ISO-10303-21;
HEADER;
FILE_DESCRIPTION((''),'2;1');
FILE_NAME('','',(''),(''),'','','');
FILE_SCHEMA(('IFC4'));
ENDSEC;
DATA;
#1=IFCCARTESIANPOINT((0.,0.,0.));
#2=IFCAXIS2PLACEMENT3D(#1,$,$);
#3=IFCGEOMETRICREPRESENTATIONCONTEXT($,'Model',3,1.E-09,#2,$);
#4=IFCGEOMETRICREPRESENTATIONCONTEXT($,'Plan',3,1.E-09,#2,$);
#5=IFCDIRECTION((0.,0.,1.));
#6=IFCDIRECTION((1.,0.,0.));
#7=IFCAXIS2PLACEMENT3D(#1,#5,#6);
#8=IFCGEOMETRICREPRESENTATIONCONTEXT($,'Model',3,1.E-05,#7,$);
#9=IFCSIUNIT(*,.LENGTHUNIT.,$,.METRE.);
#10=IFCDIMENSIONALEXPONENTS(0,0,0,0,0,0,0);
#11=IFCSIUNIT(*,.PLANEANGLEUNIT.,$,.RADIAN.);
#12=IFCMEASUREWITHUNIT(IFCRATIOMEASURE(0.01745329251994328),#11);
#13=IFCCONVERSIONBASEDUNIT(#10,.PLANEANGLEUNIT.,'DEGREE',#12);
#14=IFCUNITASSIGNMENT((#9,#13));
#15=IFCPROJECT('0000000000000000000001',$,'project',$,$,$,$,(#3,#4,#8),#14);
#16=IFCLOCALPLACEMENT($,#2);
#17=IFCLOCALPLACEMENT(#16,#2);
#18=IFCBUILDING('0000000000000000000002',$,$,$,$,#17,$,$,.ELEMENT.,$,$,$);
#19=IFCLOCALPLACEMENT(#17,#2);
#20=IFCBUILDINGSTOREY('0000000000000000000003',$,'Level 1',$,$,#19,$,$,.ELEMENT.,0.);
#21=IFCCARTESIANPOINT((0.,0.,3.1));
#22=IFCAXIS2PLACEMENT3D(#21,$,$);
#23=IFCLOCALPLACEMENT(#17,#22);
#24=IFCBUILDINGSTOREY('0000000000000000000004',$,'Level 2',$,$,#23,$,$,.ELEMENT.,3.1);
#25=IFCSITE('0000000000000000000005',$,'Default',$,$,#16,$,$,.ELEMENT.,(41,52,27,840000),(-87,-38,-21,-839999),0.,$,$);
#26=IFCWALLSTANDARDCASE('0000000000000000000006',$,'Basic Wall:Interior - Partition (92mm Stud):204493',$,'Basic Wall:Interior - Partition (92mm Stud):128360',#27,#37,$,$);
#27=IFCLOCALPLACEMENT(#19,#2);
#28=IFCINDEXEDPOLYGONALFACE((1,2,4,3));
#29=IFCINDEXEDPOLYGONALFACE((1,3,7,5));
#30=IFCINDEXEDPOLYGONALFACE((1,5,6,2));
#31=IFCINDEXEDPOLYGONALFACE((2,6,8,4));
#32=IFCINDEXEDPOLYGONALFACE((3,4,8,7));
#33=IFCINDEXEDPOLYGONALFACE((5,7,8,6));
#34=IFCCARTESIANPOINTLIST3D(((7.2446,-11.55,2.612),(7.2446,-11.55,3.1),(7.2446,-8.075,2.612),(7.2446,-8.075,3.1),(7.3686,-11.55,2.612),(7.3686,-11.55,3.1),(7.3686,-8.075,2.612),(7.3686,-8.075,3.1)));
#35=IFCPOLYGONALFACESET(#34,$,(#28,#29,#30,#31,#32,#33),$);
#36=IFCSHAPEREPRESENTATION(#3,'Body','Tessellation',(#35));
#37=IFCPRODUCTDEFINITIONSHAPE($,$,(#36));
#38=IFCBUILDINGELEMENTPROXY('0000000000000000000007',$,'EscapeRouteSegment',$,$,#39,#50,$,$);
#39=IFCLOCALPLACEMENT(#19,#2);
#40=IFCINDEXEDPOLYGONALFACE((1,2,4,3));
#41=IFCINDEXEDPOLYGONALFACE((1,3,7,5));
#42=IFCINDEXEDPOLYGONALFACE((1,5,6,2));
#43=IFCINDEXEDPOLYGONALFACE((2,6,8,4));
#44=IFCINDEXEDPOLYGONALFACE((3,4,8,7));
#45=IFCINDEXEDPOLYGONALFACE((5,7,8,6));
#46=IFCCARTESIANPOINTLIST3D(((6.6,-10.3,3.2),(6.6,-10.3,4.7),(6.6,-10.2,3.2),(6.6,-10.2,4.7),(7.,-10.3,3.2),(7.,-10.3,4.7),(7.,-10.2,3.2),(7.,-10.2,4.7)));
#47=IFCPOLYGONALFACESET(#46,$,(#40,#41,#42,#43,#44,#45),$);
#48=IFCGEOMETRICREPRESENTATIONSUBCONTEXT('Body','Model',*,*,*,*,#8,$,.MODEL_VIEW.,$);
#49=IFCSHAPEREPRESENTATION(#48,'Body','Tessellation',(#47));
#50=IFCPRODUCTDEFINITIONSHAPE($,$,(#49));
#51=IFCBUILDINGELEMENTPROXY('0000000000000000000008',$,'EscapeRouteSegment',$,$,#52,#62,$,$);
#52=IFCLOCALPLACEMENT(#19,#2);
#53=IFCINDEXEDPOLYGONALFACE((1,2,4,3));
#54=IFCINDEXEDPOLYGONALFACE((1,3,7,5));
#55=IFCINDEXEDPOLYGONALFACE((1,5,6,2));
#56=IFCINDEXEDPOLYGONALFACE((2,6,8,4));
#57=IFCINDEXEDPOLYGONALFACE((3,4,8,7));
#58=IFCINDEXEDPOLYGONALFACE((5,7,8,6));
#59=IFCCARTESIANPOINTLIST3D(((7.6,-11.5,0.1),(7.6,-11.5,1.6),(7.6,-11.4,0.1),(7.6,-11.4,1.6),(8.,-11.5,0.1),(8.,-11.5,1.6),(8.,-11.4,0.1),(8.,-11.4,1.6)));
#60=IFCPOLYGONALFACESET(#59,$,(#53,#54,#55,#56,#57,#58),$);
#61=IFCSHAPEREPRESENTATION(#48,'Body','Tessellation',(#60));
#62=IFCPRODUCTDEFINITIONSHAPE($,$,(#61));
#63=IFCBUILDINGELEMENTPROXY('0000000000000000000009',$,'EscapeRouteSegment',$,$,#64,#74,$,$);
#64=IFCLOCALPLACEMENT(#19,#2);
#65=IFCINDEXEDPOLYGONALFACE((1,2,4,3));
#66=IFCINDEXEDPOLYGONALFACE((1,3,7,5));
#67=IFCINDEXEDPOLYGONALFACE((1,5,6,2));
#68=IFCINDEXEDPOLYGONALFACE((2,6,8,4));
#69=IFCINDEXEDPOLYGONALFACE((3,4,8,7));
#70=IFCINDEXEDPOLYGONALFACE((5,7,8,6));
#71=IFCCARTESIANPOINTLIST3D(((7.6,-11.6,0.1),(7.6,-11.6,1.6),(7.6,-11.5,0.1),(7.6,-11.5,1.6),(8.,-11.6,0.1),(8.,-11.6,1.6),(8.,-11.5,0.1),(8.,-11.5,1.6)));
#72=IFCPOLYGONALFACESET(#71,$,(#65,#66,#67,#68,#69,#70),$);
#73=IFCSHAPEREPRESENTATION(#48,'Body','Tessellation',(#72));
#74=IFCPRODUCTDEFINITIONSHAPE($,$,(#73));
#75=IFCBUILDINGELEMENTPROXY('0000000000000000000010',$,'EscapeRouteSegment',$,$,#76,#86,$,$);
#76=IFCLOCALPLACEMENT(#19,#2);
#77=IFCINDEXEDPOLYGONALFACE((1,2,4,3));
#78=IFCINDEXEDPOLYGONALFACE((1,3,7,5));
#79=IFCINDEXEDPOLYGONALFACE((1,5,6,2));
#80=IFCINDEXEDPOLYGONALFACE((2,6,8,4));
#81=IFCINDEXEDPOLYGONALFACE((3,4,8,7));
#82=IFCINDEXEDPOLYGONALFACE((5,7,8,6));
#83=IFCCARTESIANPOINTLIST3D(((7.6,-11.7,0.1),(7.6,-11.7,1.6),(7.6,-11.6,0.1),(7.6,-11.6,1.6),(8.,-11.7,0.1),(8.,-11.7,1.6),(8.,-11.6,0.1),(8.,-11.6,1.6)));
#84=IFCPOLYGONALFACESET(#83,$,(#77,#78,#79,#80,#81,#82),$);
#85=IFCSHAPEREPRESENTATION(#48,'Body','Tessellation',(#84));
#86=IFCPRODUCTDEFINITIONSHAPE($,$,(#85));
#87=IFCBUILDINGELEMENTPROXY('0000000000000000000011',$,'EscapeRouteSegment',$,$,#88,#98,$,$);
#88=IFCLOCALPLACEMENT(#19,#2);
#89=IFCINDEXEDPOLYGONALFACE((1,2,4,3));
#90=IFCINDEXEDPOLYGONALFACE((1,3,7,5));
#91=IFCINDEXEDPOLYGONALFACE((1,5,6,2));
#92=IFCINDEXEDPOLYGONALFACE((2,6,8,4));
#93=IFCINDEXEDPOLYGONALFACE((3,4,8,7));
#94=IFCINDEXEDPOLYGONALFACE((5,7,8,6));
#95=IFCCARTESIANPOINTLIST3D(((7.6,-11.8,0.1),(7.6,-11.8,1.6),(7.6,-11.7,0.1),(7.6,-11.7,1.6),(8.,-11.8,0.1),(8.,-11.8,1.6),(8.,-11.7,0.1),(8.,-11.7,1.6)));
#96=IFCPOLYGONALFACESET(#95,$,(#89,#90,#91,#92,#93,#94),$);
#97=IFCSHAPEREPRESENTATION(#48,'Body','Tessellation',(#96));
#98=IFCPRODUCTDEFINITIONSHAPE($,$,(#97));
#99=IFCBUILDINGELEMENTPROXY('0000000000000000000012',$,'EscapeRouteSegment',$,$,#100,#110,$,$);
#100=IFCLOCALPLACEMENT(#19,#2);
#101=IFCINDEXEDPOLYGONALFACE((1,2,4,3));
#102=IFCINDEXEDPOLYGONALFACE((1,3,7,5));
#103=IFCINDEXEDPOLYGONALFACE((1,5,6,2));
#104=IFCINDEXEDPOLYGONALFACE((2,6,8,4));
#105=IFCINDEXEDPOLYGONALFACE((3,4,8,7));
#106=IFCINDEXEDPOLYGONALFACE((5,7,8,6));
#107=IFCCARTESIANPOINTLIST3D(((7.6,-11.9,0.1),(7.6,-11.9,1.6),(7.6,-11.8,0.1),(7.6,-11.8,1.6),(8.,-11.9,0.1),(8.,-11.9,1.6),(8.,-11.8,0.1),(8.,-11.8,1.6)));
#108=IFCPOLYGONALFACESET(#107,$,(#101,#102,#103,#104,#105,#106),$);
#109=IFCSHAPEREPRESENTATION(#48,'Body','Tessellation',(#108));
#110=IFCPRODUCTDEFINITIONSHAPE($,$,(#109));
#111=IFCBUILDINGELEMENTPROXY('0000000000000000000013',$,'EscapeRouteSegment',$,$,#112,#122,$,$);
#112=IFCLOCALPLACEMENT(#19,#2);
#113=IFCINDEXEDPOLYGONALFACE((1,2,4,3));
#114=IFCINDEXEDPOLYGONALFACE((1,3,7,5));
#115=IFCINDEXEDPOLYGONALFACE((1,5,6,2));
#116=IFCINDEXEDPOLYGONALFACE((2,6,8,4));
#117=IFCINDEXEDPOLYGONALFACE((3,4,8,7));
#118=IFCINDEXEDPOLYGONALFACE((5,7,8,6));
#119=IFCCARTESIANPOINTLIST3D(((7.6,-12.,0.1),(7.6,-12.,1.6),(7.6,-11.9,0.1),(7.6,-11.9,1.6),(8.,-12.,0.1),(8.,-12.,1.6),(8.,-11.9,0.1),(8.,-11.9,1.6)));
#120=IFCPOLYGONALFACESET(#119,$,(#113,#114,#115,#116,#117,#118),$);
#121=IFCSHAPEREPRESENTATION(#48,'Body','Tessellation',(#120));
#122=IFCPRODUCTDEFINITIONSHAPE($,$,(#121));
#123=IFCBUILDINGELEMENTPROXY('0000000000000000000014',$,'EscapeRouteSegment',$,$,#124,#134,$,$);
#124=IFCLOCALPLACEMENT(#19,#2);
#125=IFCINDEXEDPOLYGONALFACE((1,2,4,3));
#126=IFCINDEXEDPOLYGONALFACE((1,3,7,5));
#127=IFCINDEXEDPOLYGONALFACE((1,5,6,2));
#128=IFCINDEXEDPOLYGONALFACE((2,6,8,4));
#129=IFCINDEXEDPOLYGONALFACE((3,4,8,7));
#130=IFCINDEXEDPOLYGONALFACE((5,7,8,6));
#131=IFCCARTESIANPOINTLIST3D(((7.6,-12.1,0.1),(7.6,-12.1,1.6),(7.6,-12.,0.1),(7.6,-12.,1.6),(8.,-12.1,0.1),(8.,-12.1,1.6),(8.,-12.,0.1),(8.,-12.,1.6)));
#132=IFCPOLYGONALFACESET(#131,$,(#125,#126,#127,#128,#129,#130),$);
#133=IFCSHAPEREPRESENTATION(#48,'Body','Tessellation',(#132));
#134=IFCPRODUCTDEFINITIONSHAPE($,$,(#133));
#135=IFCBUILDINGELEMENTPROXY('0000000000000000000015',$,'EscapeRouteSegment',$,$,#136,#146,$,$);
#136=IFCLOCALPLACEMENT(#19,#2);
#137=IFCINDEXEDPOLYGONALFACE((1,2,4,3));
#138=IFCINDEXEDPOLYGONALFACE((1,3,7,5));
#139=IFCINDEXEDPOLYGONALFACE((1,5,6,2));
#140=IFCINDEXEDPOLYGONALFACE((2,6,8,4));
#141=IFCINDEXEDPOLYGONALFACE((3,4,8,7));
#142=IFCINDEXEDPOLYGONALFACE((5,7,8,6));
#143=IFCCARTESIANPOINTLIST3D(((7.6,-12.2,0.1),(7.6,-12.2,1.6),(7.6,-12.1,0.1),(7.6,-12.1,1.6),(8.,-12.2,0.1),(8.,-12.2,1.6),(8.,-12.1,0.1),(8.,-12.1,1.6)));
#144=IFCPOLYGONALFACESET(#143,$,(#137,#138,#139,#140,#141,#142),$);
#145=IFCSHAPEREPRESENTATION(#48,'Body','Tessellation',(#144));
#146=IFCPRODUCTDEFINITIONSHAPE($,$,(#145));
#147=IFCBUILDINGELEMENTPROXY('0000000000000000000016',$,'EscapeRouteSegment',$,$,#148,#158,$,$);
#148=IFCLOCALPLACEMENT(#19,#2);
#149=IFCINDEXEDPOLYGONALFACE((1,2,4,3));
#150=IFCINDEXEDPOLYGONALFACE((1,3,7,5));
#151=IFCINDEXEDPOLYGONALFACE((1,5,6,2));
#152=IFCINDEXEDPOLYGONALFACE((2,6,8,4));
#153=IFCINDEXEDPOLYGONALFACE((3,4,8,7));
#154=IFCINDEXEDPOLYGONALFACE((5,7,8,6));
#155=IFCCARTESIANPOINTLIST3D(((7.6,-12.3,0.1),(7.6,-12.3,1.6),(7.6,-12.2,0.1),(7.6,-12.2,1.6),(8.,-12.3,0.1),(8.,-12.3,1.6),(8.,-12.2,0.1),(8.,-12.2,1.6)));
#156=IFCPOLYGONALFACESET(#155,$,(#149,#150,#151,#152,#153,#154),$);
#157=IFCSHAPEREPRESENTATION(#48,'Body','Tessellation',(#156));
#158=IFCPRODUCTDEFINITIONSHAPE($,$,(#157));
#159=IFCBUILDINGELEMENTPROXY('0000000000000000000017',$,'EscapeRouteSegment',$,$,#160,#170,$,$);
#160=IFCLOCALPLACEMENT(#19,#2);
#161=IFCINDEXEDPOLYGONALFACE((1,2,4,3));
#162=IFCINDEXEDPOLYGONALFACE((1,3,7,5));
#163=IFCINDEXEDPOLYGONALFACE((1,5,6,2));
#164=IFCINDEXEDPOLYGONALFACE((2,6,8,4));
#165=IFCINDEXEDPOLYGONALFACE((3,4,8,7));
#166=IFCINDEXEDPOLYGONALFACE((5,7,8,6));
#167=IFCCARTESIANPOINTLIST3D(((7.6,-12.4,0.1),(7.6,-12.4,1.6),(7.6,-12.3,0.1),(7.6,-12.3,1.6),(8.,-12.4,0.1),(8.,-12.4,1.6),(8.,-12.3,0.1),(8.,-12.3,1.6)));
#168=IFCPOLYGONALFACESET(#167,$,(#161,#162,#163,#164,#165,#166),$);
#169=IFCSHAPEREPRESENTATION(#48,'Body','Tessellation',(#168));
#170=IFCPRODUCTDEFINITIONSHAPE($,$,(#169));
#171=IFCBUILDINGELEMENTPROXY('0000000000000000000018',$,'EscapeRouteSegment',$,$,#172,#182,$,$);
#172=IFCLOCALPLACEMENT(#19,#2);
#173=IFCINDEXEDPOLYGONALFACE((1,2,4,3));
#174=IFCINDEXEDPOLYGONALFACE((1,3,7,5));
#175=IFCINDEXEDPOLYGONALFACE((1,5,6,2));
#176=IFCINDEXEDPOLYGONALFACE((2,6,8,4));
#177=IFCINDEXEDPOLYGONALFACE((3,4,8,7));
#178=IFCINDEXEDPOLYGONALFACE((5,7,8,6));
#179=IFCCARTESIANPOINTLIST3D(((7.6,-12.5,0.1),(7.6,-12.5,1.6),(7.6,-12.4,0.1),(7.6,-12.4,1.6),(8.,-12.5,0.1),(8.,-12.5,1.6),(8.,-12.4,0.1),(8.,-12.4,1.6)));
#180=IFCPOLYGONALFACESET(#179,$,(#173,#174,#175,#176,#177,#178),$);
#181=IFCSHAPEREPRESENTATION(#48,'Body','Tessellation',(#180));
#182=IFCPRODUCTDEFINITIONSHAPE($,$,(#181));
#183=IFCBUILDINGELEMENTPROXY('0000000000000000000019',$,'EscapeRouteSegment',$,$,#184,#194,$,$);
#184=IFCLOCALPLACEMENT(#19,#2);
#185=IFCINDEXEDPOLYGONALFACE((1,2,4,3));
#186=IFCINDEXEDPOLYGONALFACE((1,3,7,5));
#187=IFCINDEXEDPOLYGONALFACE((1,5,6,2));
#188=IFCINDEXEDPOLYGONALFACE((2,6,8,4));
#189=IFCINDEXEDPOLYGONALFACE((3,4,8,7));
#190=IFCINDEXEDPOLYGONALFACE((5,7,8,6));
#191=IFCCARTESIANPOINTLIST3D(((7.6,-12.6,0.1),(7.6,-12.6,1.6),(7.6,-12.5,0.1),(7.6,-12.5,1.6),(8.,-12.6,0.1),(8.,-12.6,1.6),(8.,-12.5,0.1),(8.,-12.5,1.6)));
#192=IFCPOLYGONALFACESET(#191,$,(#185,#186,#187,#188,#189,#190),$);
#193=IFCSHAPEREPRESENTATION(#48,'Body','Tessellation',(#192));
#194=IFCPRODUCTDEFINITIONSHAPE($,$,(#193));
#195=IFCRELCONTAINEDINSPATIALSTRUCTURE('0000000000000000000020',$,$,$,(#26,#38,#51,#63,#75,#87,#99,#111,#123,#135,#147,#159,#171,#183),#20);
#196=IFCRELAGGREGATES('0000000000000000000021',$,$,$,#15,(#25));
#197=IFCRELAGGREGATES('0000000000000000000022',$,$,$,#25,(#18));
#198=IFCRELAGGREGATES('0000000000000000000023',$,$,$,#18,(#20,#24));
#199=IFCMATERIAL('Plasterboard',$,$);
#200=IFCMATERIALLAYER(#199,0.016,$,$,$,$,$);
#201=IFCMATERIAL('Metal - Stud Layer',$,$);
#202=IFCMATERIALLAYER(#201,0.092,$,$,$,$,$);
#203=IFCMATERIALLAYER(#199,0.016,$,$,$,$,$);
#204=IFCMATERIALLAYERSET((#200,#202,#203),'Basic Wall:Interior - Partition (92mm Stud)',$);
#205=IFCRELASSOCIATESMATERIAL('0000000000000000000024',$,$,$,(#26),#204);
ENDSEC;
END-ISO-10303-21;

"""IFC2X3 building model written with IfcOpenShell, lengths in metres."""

from ifc_helpers import new_model, entity, si_unit, converted_unit, frame, frame_2d, origin, origin_with_axes, place, context, subcontext, project, spatial, polyline, rectangle, outline, extrude, material, layer, layer_set, layer_usage, element, save


model = new_model("IFC2X3")

# Units and contexts
model_context_1 = context("Model", 3, precision=1e-09, world=origin())
plan_context = context("Plan", 3, precision=1e-09, world=origin())
model_context_2 = context("Model", 3, precision=1e-05, world=origin_with_axes())
body_context = subcontext(model_context_2, "Body", "Model", "MODEL_VIEW")
ifc_project = project(units=[si_unit("LENGTHUNIT", "METRE"), converted_unit("PLANEANGLEUNIT", "DEGREE", entity("IfcRatioMeasure", 0.01745329251994328), si_unit("PLANEANGLEUNIT", "RADIAN"), dimensions=[0, 0, 0, 0, 0, 0, 0])], contexts=[model_context_1, plan_context, model_context_2])

# Site, building, storey
site_placement = place(None, origin())
site = spatial("IfcSite", under=ifc_project, at=site_placement, Name="Default", CompositionType="ELEMENT", RefLatitude=(41, 52, 27, 840000), RefLongitude=(-87, -38, -21, -839999), RefElevation=0.0)
building_placement = place(site_placement, origin())
building = spatial("IfcBuilding", under=site, at=building_placement, CompositionType="ELEMENT")
storey_1_placement = place(building_placement, origin())
storey_1 = spatial("IfcBuildingStorey", under=building, at=storey_1_placement, Name="Level 1", CompositionType="ELEMENT", Elevation=0.0)

# Shared definitions
ifc_material_1 = material(Name="Plasterboard")
ifc_layer_1 = layer(ifc_material_1, 0.016)
ifc_material_2 = material(Name="Metal - Stud Layer")
ifc_layer_2 = layer(ifc_material_2, 0.092)
ifc_layer_3 = layer(ifc_material_1, 0.016)
ifc_layer_set = layer_set([ifc_layer_1, ifc_layer_2, ifc_layer_3], Name="Basic Wall:Interior - Partition (92mm Stud)")

# Shared definitions
storey_2_placement = place(building_placement, frame((0.0, 0.0, 3.1)))
storey_2 = spatial("IfcBuildingStorey", under=building, at=storey_2_placement, Name="Level 2", CompositionType="ELEMENT", Elevation=3.1)

# Wall
ifc_layer_usage_1 = layer_usage(ifc_layer_set, "AXIS2", "NEGATIVE", 0.062)
wall_1_placement = place(storey_1_placement, frame((7.3066, -11.55, 2.612), z_axis=(0.0, 0.0, 1.0), x_axis=(0.0, 1.0, 0.0)))
element("IfcWallStandardCase", 1, at=wall_1_placement, inside=storey_1, material=ifc_layer_usage_1, Name="Basic Wall:Interior - Partition (92mm Stud):204493", ObjectType="Basic Wall:Interior - Partition (92mm Stud):128360", context=model_context_1, shape_type="SweptSolid", body=[
    extrude(rectangle(XDim=3.475, YDim=0.124, at=frame_2d((1.7375, 0.0), x_axis=(-1.0, 0.0))), origin(), (0.0, 0.0, 1.0), 0.488),
])

# Building element proxies
for number, where, z_axis, x_axis, name in (
    (2, (6.8, -10.3, 3.2), (0.0, 0.0, 1.0), (0.0, 1.0, 0.0), "EscapeRouteSegment"),
    (3, (7.8, -11.4, 0.1), (0.0, 0.0, 1.0), (0.0, -1.0, 0.0), "EscapeRouteSegment"),
    (4, (7.8, -11.5, 0.1), (0.0, 0.0, 1.0), (0.0, -1.0, 0.0), "EscapeRouteSegment"),
):
    element("IfcBuildingElementProxy", number, at=place(storey_1_placement, frame(where, z_axis=z_axis, x_axis=x_axis)), inside=storey_1, Name=name, context=body_context, shape_type="SweptSolid", body=[
        extrude(outline(polyline([(0.0, -0.2), (0.0, 0.2), (0.1, 0.2), (0.1, -0.2), (0.0, -0.2)])), origin_with_axes(), (0.0, 0.0, 1.0), 1.5),
    ])
proxy_1_placement = place(storey_1_placement, frame((7.8, -11.6, 0.1), z_axis=(0.0, 0.0, 1.0), x_axis=(0.0, -1.0, 0.0)))
element("IfcBuildingElementProxy", 5, at=proxy_1_placement, inside=storey_1, Name="EscapeRouteSegment", context=body_context, shape_type="SweptSolid", body=[
    extrude(outline(polyline([(0.0, -0.2), (0.0, 0.2), (0.1, 0.2), (0.1, -0.2), (0.0, -0.2)])), origin_with_axes(), (0.0, 0.0, 1.0), 1.5),
])
proxy_2_placement = place(storey_1_placement, frame((7.8, -11.7, 0.1), z_axis=(0.0, 0.0, 1.0), x_axis=(0.0, -1.0, 0.0)))
element("IfcBuildingElementProxy", 6, at=proxy_2_placement, inside=storey_1, Name="EscapeRouteSegment", context=body_context, shape_type="SweptSolid", body=[
    extrude(outline(polyline([(0.0, -0.2), (0.0, 0.2), (0.1, 0.2), (0.1, -0.2), (0.0, -0.2)])), origin_with_axes(), (0.0, 0.0, 1.0), 1.5),
])
proxy_3_placement = place(storey_1_placement, frame((7.8, -11.8, 0.1), z_axis=(0.0, 0.0, 1.0), x_axis=(0.0, -1.0, 0.0)))
element("IfcBuildingElementProxy", 7, at=proxy_3_placement, inside=storey_1, Name="EscapeRouteSegment", context=body_context, shape_type="SweptSolid", body=[
    extrude(outline(polyline([(0.0, -0.2), (0.0, 0.2), (0.1, 0.2), (0.1, -0.2), (0.0, -0.2)])), origin_with_axes(), (0.0, 0.0, 1.0), 1.5),
])
for number, where, z_axis, x_axis, name in (
    (8, (7.8, -11.9, 0.1), (0.0, 0.0, 1.0), (0.0, -1.0, 0.0), "EscapeRouteSegment"),
    (9, (7.8, -12.0, 0.1), (0.0, 0.0, 1.0), (0.0, -1.0, 0.0), "EscapeRouteSegment"),
):
    element("IfcBuildingElementProxy", number, at=place(storey_1_placement, frame(where, z_axis=z_axis, x_axis=x_axis)), inside=storey_1, Name=name, context=body_context, shape_type="SweptSolid", body=[
        extrude(outline(polyline([(0.0, -0.2), (0.0, 0.2), (0.1, 0.2), (0.1, -0.2), (0.0, -0.2)])), origin_with_axes(), (0.0, 0.0, 1.0), 1.5),
    ])
proxy_4_placement = place(storey_1_placement, frame((7.8, -12.1, 0.1), z_axis=(0.0, 0.0, 1.0), x_axis=(0.0, -1.0, 0.0)))
element("IfcBuildingElementProxy", 10, at=proxy_4_placement, inside=storey_1, Name="EscapeRouteSegment", context=body_context, shape_type="SweptSolid", body=[
    extrude(outline(polyline([(0.0, -0.2), (0.0, 0.2), (0.1, 0.2), (0.1, -0.2), (0.0, -0.2)])), origin_with_axes(), (0.0, 0.0, 1.0), 1.5),
])
proxy_5_placement = place(storey_1_placement, frame((7.8, -12.2, 0.1), z_axis=(0.0, 0.0, 1.0), x_axis=(0.0, -1.0, 0.0)))
element("IfcBuildingElementProxy", 11, at=proxy_5_placement, inside=storey_1, Name="EscapeRouteSegment", context=body_context, shape_type="SweptSolid", body=[
    extrude(outline(polyline([(0.0, -0.2), (0.0, 0.2), (0.1, 0.2), (0.1, -0.2), (0.0, -0.2)])), origin_with_axes(), (0.0, 0.0, 1.0), 1.5),
])
proxy_6_placement = place(storey_1_placement, frame((7.8, -12.3, 0.1), z_axis=(0.0, 0.0, 1.0), x_axis=(0.0, -1.0, 0.0)))
element("IfcBuildingElementProxy", 12, at=proxy_6_placement, inside=storey_1, Name="EscapeRouteSegment", context=body_context, shape_type="SweptSolid", body=[
    extrude(outline(polyline([(0.0, -0.2), (0.0, 0.2), (0.1, 0.2), (0.1, -0.2), (0.0, -0.2)])), origin_with_axes(), (0.0, 0.0, 1.0), 1.5),
])
for number, where, z_axis, x_axis, name in (
    (13, (7.8, -12.4, 0.1), (0.0, 0.0, 1.0), (0.0, -1.0, 0.0), "EscapeRouteSegment"),
    (14, (7.8, -12.5, 0.1), (0.0, 0.0, 1.0), (0.0, -1.0, 0.0), "EscapeRouteSegment"),
):
    element("IfcBuildingElementProxy", number, at=place(storey_1_placement, frame(where, z_axis=z_axis, x_axis=x_axis)), inside=storey_1, Name=name, context=body_context, shape_type="SweptSolid", body=[
        extrude(outline(polyline([(0.0, -0.2), (0.0, 0.2), (0.1, 0.2), (0.1, -0.2), (0.0, -0.2)])), origin_with_axes(), (0.0, 0.0, 1.0), 1.5),
    ])

save(model, "model.ifc")
